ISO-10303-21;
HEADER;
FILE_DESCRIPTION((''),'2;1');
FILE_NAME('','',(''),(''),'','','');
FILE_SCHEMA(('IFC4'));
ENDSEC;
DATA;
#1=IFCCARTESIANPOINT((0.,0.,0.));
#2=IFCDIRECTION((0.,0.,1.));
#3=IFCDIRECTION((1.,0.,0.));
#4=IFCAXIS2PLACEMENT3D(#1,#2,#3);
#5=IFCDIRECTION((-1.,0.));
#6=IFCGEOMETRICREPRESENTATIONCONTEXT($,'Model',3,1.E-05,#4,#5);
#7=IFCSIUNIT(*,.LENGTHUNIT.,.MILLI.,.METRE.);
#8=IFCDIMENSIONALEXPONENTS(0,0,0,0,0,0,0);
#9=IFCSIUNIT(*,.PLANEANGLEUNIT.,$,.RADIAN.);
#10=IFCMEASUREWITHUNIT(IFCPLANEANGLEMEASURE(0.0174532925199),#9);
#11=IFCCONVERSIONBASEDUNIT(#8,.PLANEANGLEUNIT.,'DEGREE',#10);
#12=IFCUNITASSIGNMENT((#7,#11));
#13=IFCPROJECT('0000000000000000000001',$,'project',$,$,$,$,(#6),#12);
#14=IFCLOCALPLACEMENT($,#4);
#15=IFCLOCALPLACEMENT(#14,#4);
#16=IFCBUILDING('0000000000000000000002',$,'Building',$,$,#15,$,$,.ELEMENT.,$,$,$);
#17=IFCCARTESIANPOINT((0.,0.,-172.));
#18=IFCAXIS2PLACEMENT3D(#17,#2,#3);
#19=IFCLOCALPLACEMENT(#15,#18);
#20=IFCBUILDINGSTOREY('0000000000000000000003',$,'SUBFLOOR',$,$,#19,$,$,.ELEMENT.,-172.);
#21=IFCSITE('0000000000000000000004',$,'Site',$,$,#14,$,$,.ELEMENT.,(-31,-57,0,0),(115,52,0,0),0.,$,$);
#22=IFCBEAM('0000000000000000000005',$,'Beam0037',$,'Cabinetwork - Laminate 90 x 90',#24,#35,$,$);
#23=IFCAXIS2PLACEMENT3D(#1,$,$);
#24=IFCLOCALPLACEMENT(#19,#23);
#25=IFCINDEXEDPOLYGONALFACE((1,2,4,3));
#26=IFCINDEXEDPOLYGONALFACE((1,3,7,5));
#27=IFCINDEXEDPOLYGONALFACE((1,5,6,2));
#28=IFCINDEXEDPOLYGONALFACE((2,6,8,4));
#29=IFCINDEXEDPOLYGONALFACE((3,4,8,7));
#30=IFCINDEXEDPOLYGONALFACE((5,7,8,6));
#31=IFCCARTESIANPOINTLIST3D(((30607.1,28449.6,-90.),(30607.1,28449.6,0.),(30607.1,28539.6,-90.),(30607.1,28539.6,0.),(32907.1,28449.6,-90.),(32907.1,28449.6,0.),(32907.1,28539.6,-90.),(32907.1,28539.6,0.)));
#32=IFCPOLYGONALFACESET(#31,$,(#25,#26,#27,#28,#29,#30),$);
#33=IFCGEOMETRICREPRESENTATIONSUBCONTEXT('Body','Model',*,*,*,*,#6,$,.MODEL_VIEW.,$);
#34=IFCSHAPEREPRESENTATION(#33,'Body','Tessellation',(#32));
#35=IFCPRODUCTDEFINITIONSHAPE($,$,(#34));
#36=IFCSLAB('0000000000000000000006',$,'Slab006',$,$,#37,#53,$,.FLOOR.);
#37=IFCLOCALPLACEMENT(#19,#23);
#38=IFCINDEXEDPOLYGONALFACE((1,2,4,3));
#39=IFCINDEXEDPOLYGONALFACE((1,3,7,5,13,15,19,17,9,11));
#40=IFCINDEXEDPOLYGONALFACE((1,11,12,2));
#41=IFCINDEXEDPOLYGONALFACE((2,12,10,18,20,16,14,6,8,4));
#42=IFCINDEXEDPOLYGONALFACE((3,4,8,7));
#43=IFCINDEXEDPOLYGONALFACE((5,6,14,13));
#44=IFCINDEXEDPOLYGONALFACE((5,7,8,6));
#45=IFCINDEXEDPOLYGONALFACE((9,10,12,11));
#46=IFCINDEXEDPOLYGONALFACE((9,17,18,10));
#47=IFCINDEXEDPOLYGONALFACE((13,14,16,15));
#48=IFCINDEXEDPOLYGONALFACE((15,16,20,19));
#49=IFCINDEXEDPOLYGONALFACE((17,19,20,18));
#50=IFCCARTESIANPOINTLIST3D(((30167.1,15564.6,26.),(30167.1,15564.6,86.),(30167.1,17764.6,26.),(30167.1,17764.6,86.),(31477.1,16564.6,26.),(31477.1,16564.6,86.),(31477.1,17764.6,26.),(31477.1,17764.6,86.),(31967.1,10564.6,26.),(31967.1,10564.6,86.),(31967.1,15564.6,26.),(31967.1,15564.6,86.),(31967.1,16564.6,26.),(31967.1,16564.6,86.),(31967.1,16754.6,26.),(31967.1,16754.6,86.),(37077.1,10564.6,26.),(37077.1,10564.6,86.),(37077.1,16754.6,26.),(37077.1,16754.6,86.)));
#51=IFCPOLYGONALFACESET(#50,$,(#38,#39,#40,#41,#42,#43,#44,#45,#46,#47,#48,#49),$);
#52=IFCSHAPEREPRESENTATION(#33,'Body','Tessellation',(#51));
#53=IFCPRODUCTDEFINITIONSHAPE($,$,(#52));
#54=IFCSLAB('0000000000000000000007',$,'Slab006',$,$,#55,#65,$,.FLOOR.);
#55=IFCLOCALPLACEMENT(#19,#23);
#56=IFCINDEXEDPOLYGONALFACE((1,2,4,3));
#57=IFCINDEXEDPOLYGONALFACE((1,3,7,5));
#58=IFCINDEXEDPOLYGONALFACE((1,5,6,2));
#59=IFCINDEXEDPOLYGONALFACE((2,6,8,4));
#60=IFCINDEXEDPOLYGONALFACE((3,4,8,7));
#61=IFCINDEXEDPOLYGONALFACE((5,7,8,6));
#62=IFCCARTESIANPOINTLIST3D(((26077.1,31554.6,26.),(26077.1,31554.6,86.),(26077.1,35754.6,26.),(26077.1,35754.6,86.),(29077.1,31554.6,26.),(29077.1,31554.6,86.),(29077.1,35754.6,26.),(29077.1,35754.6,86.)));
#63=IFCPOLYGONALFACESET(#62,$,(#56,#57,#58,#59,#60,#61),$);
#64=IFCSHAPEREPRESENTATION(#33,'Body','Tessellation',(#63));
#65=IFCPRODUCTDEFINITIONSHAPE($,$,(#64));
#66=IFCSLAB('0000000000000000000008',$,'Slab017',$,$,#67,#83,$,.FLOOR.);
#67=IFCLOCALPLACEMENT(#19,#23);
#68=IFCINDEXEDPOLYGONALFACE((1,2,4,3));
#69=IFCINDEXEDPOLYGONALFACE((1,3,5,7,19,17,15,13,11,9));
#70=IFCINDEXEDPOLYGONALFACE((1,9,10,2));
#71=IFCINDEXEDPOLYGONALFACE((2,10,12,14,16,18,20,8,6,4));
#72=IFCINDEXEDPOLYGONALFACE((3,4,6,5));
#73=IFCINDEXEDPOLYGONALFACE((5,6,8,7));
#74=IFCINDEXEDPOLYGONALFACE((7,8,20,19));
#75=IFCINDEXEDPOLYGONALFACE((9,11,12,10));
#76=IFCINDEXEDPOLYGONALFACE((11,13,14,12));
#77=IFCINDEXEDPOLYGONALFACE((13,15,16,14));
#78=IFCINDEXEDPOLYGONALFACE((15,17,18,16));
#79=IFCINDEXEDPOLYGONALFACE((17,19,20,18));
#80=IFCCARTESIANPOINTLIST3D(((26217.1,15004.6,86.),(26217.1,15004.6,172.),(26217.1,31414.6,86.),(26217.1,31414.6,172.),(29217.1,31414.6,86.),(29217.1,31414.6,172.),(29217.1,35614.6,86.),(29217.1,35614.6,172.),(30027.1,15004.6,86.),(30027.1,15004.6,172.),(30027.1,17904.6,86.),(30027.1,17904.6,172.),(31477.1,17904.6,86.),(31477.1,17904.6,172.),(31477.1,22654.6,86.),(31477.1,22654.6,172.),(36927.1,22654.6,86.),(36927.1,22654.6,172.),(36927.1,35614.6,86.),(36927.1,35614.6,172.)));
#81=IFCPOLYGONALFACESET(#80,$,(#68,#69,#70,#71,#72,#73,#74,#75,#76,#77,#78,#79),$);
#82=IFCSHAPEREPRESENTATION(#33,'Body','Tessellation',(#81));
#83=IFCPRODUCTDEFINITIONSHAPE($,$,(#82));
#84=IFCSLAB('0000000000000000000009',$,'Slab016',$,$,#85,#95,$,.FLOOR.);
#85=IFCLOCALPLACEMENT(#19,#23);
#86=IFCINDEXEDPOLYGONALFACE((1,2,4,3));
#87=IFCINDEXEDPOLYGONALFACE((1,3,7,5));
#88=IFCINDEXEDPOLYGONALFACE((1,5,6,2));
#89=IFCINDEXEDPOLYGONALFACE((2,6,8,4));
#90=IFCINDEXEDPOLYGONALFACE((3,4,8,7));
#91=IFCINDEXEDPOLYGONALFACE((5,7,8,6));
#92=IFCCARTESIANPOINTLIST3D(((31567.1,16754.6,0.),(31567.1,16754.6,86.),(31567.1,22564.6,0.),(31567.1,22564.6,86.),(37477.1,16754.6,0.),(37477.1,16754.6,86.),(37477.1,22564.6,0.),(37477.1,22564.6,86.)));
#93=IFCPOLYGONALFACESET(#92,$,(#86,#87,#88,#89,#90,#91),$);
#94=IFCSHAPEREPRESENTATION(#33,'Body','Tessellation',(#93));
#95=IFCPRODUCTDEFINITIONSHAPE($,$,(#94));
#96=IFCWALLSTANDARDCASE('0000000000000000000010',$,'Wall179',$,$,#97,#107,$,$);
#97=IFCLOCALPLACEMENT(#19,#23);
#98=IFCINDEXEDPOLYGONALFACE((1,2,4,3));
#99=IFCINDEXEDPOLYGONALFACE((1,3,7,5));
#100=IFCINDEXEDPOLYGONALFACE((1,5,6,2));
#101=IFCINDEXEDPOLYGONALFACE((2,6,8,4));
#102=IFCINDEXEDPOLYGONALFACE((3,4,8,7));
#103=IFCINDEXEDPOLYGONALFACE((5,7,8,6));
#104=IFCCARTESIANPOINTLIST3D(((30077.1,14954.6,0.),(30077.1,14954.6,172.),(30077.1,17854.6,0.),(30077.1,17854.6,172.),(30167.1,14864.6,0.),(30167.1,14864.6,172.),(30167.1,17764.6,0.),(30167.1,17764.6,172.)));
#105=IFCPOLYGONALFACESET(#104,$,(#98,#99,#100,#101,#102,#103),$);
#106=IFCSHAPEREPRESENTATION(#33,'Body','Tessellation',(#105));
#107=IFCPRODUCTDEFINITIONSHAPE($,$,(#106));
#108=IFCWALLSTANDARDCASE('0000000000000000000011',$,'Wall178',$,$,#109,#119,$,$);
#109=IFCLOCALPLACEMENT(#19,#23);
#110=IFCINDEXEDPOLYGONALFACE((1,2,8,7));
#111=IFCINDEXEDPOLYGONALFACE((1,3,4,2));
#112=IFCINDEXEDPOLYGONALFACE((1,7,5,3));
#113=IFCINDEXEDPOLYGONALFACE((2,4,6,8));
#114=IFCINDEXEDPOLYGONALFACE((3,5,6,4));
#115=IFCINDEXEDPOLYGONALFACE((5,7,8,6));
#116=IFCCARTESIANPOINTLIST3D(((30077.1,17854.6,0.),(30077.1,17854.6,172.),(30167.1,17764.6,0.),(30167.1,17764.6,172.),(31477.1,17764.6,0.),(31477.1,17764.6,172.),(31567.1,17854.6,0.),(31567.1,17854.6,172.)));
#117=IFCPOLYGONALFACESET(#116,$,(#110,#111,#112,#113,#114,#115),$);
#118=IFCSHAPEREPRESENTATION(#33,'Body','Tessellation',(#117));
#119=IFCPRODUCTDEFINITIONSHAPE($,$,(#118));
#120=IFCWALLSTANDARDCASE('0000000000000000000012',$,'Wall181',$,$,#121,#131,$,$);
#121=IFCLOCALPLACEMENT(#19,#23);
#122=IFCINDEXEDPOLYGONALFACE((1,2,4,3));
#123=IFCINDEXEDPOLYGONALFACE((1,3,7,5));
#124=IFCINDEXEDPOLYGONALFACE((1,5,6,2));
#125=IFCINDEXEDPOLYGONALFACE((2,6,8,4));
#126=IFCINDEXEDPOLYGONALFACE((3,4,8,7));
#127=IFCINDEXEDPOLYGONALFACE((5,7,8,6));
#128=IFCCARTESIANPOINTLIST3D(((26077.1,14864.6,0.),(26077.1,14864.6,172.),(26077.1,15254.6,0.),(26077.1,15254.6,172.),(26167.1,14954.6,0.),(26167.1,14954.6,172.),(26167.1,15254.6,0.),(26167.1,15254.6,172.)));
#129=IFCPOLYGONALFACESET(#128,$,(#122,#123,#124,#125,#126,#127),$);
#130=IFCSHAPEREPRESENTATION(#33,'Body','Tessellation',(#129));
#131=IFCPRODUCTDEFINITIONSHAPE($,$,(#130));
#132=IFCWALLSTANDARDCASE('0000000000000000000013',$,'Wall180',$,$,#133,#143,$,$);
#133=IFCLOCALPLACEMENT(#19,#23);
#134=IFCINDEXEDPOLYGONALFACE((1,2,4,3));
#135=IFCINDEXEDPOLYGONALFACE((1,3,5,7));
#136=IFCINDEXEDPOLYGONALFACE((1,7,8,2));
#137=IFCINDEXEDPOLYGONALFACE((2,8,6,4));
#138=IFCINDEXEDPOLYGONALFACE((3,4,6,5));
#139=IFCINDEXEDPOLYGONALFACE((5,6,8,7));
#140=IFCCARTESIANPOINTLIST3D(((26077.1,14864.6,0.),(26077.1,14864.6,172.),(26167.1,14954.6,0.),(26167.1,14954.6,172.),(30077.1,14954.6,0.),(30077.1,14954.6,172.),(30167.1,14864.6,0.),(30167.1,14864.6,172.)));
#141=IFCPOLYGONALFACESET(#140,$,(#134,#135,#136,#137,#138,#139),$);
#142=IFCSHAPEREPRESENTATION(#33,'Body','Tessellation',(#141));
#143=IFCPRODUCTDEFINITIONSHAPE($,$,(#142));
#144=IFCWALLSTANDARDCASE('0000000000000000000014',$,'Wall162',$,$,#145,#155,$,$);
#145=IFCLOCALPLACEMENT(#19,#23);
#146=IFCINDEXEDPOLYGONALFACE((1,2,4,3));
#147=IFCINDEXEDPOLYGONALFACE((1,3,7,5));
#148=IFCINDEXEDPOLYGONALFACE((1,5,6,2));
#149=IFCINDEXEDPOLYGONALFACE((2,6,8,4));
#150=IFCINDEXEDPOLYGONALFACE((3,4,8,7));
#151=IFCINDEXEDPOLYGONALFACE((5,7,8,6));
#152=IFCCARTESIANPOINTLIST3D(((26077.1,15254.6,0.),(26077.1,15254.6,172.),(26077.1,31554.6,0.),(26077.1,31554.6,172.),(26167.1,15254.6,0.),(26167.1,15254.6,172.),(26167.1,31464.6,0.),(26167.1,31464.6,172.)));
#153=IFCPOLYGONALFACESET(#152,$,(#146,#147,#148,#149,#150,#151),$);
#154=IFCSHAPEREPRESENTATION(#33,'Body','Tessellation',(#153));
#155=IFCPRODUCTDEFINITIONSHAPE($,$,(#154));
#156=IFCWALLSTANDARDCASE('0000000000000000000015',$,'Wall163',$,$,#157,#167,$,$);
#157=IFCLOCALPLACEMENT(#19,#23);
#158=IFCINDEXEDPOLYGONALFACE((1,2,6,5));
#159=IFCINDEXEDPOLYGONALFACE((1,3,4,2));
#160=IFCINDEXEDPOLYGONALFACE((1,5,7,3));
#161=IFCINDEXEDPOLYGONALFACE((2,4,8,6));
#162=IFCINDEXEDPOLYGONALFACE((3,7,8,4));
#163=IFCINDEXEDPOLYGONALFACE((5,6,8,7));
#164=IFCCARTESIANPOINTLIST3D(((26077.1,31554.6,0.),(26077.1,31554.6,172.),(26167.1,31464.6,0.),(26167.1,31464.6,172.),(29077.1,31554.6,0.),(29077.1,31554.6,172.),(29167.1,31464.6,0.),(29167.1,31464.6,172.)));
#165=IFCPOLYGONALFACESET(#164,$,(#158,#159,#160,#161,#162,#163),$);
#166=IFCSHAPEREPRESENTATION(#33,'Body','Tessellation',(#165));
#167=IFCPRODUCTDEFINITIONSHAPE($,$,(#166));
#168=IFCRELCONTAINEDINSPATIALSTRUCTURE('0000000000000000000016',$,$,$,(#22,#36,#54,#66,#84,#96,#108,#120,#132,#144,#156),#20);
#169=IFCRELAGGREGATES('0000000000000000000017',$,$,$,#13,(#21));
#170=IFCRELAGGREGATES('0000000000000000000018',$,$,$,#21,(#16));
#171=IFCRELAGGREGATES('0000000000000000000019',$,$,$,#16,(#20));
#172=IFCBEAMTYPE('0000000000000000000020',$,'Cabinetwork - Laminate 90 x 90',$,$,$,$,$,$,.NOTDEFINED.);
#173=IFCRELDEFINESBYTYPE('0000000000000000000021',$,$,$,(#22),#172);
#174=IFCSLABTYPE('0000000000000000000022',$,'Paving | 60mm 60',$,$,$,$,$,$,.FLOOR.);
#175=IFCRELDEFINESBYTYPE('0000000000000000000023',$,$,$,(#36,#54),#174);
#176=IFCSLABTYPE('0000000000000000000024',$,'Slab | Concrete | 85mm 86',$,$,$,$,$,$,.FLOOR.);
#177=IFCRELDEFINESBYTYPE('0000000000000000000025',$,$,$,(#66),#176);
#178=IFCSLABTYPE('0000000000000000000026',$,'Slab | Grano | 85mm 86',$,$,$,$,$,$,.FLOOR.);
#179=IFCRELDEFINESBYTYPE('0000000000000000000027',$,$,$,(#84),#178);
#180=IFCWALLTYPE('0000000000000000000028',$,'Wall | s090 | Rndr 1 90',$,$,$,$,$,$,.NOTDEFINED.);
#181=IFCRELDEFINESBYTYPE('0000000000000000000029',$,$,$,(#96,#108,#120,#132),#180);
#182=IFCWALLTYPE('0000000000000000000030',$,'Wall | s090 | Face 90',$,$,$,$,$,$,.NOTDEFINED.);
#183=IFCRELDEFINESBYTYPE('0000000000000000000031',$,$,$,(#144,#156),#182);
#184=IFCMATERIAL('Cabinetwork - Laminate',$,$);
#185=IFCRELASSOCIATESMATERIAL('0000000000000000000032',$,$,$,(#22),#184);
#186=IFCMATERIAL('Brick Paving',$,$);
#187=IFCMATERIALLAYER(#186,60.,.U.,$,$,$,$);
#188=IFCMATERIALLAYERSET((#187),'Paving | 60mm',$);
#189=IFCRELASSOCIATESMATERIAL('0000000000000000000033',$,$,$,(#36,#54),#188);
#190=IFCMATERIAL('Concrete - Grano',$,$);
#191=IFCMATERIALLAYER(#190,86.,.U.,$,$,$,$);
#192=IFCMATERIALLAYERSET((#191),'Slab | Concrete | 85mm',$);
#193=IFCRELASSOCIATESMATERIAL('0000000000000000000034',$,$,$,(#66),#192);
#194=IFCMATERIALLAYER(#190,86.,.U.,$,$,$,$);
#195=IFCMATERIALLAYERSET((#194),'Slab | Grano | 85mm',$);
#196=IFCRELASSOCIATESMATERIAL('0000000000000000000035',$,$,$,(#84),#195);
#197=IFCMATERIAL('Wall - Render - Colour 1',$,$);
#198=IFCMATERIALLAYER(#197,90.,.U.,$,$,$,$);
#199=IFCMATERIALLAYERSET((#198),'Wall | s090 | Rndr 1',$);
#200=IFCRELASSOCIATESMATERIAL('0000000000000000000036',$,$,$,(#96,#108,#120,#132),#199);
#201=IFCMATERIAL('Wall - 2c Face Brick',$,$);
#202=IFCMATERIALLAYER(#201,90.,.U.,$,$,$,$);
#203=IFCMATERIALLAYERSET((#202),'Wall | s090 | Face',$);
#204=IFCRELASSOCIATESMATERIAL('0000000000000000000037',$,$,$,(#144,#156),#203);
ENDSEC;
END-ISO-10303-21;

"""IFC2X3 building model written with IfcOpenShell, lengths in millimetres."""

from ifc_helpers import new_model, entity, si_unit, converted_unit, direction, frame, frame_2d, origin_with_axes, place, context, subcontext, project, spatial, polyline, rectangle, outline, extrude, material, layer, layer_set, layer_usage, type_object, element, save


model = new_model("IFC2X3")

# Units and contexts
model_context = context("Model", 3, precision=1e-05, world=origin_with_axes(), true_north=direction((-1.0, 0.0)))
body_context = subcontext(model_context, "Body", "Model", "MODEL_VIEW")
ifc_project = project(units=[si_unit("LENGTHUNIT", "METRE", prefix="MILLI"), converted_unit("PLANEANGLEUNIT", "DEGREE", entity("IfcPlaneAngleMeasure", 0.0174532925199), si_unit("PLANEANGLEUNIT", "RADIAN"), dimensions=[0, 0, 0, 0, 0, 0, 0])], contexts=[model_context])

# Site, building, storey
site_placement = place(None, origin_with_axes())
site = spatial("IfcSite", under=ifc_project, at=site_placement, Name="Site", CompositionType="ELEMENT", RefLatitude=(-31, -57, 0, 0), RefLongitude=(115, 52, 0, 0), RefElevation=0.0)
building_placement = place(site_placement, origin_with_axes())
building = spatial("IfcBuilding", under=site, at=building_placement, Name="Building", CompositionType="ELEMENT")
storey_placement = place(building_placement, frame((0.0, 0.0, -172.0), z_axis=(0.0, 0.0, 1.0), x_axis=(1.0, 0.0, 0.0)))
storey = spatial("IfcBuildingStorey", under=building, at=storey_placement, Name="SUBFLOOR", CompositionType="ELEMENT", Elevation=-172.0)

# Beam
ifc_material_1 = material(Name="Cabinetwork - Laminate")
beam_type = type_object("IfcBeamType", Name="Cabinetwork - Laminate 90 x 90", PredefinedType="NOTDEFINED")
beam_placement = place(storey_placement, frame((30607.1, 28494.6, 0.0), z_axis=(0.0, 0.0, 1.0), x_axis=(0.0, -1.0, 0.0)))
element("IfcBeam", 1, at=beam_placement, inside=storey, type_object=beam_type, material=ifc_material_1, Name="Beam0037", ObjectType="Cabinetwork - Laminate 90 x 90", context=body_context, shape_type="SweptSolid", body=[
    extrude(rectangle(XDim=90.0, YDim=90.0, at=frame_2d((-45.0, 0.0), x_axis=(1.0, 0.0))), frame((0.0, 0.0, 0.0), z_axis=(0.0, 1.0, 0.0), x_axis=(0.0, 0.0, 1.0)), (0.0, 0.0, 1.0), 2300.0),
])

# Slabs
ifc_material_2 = material(Name="Brick Paving")
ifc_layer_1 = layer(ifc_material_2, 60.0, ventilated="UNKNOWN")
ifc_layer_set_1 = layer_set([ifc_layer_1], Name="Paving | 60mm")
ifc_layer_usage_1 = layer_usage(ifc_layer_set_1, "AXIS3", "NEGATIVE", 60.0)
slab_type_1 = type_object("IfcSlabType", Name="Paving | 60mm 60", PredefinedType="FLOOR")
slab_1_placement = place(storey_placement, frame((31477.1, 17764.6, 86.0), z_axis=(0.0, 0.0, 1.0), x_axis=(1.0, 0.0, 0.0)))
element("IfcSlab", 2, at=slab_1_placement, inside=storey, type_object=slab_type_1, material=ifc_layer_usage_1, Name="Slab006", PredefinedType="FLOOR", context=body_context, shape_type="SweptSolid", body=[
    extrude(outline(polyline([(0.0, 0.0), (-1310.0, 0.0), (-1310.0, -2200.0), (490.0, -2200.0), (490.0, -7200.0), (5600.0, -7200.0), (5600.0, -1010.0), (490.0, -1010.0), (490.0, -1200.0), (0.0, -1200.0), (0.0, 0.0)])), frame((0.0, 0.0, -60.0), z_axis=(0.0, 0.0, 1.0), x_axis=(1.0, 0.0, 0.0)), (0.0, 0.0, 1.0), 60.0),
])
ifc_layer_usage_2 = layer_usage(ifc_layer_set_1, "AXIS3", "NEGATIVE", 60.0)
slab_2_placement = place(storey_placement, frame((26077.1, 31554.6, 86.0), z_axis=(0.0, 0.0, 1.0), x_axis=(1.0, 0.0, 0.0)))
element("IfcSlab", 3, at=slab_2_placement, inside=storey, type_object=slab_type_1, material=ifc_layer_usage_2, Name="Slab006", PredefinedType="FLOOR", context=body_context, shape_type="SweptSolid", body=[
    extrude(outline(polyline([(0.0, 0.0), (3000.0, 0.0), (3000.0, 4200.0), (0.0, 4200.0), (0.0, 0.0)])), frame((0.0, 0.0, -60.0), z_axis=(0.0, 0.0, 1.0), x_axis=(1.0, 0.0, 0.0)), (0.0, 0.0, 1.0), 60.0),
])
ifc_material_3 = material(Name="Concrete - Grano")
ifc_layer_2 = layer(ifc_material_3, 86.0, ventilated="UNKNOWN")
ifc_layer_set_2 = layer_set([ifc_layer_2], Name="Slab | Concrete | 85mm")
ifc_layer_usage_3 = layer_usage(ifc_layer_set_2, "AXIS3", "NEGATIVE", 86.0)
slab_type_2 = type_object("IfcSlabType", Name="Slab | Concrete | 85mm 86", PredefinedType="FLOOR")
slab_3_placement = place(storey_placement, frame((29217.1, 31414.6, 172.0), z_axis=(0.0, 0.0, 1.0), x_axis=(1.0, 0.0, 0.0)))
element("IfcSlab", 4, at=slab_3_placement, inside=storey, type_object=slab_type_2, material=ifc_layer_usage_3, Name="Slab017", PredefinedType="FLOOR", context=body_context, shape_type="SweptSolid", body=[
    extrude(outline(polyline([(0.0, 0.0), (-3000.0, 0.0), (-3000.0, -16410.0), (810.0, -16410.0), (810.0, -13510.0), (2260.0, -13510.0), (2260.0, -8760.0), (7710.0, -8760.0), (7710.0, 4200.0), (0.0, 4200.0), (0.0, 0.0)])), frame((0.0, 0.0, -86.0), z_axis=(0.0, 0.0, 1.0), x_axis=(1.0, 0.0, 0.0)), (0.0, 0.0, 1.0), 86.0),
])
ifc_layer_3 = layer(ifc_material_3, 86.0, ventilated="UNKNOWN")
ifc_layer_set_3 = layer_set([ifc_layer_3], Name="Slab | Grano | 85mm")
ifc_layer_usage_4 = layer_usage(ifc_layer_set_3, "AXIS3", "NEGATIVE", 86.0)
slab_type_3 = type_object("IfcSlabType", Name="Slab | Grano | 85mm 86", PredefinedType="FLOOR")
slab_4_placement = place(storey_placement, frame((37477.1, 22564.6, 86.0), z_axis=(0.0, 0.0, 1.0), x_axis=(1.0, 0.0, 0.0)))
element("IfcSlab", 5, at=slab_4_placement, inside=storey, type_object=slab_type_3, material=ifc_layer_usage_4, Name="Slab016", PredefinedType="FLOOR", context=body_context, shape_type="SweptSolid", body=[
    extrude(outline(polyline([(0.0, 0.0), (-5910.0, 0.0), (-5910.0, -5810.0), (0.0, -5810.0), (0.0, 0.0)])), frame((0.0, 0.0, -86.0), z_axis=(0.0, 0.0, 1.0), x_axis=(1.0, 0.0, 0.0)), (0.0, 0.0, 1.0), 86.0),
])

# Walls
ifc_material_4 = material(Name="Wall - Render - Colour 1")
ifc_layer_4 = layer(ifc_material_4, 90.0, ventilated="UNKNOWN")
ifc_layer_set_4 = layer_set([ifc_layer_4], Name="Wall | s090 | Rndr 1")
ifc_layer_usage_5 = layer_usage(ifc_layer_set_4, "AXIS2", "NEGATIVE", 0.0)
wall_type_1 = type_object("IfcWallType", Name="Wall | s090 | Rndr 1 90", PredefinedType="NOTDEFINED")
wall_1_placement = place(storey_placement, frame((30167.1, 17764.6, 0.0), z_axis=(0.0, 0.0, 1.0), x_axis=(0.0, -1.0, 0.0)))
element("IfcWallStandardCase", 6, at=wall_1_placement, inside=storey, type_object=wall_type_1, material=ifc_layer_usage_5, Name="Wall179", context=body_context, shape_type="SweptSolid", body=[
    extrude(outline(polyline([(-90.0, -90.0), (2810.0, -90.0), (2900.0, 0.0), (0.0, 0.0), (-90.0, -90.0)])), origin_with_axes(), (0.0, 0.0, 1.0), 172.0),
])
ifc_layer_usage_6 = layer_usage(ifc_layer_set_4, "AXIS2", "NEGATIVE", 0.0)
wall_2_placement = place(storey_placement, frame((31477.1, 17764.6, 0.0), z_axis=(0.0, 0.0, 1.0), x_axis=(-1.0, 0.0, 0.0)))
element("IfcWallStandardCase", 7, at=wall_2_placement, inside=storey, type_object=wall_type_1, material=ifc_layer_usage_6, Name="Wall178", context=body_context, shape_type="SweptSolid", body=[
    extrude(outline(polyline([(-90.0, -90.0), (1400.0, -90.0), (1310.0, 0.0), (0.0, 0.0), (-90.0, -90.0)])), origin_with_axes(), (0.0, 0.0, 1.0), 172.0),
])
ifc_layer_usage_7 = layer_usage(ifc_layer_set_4, "AXIS2", "NEGATIVE", 0.0)
wall_3_placement = place(storey_placement, frame((26077.1, 14864.6, 0.0), z_axis=(0.0, 0.0, 1.0), x_axis=(0.0, 1.0, 0.0)))
element("IfcWallStandardCase", 8, at=wall_3_placement, inside=storey, type_object=wall_type_1, material=ifc_layer_usage_7, Name="Wall181", context=body_context, shape_type="SweptSolid", body=[
    extrude(outline(polyline([(90.0, -90.0), (390.0, -90.0), (390.0, 0.0), (0.0, 0.0), (90.0, -90.0)])), origin_with_axes(), (0.0, 0.0, 1.0), 172.0),
])
ifc_layer_usage_8 = layer_usage(ifc_layer_set_4, "AXIS2", "NEGATIVE", 0.0)
wall_4_placement = place(storey_placement, frame((30167.1, 14864.6, 0.0), z_axis=(0.0, 0.0, 1.0), x_axis=(-1.0, 0.0, 0.0)))
element("IfcWallStandardCase", 9, at=wall_4_placement, inside=storey, type_object=wall_type_1, material=ifc_layer_usage_8, Name="Wall180", context=body_context, shape_type="SweptSolid", body=[
    extrude(outline(polyline([(90.0, -90.0), (4000.0, -90.0), (4090.0, 0.0), (0.0, 0.0), (90.0, -90.0)])), origin_with_axes(), (0.0, 0.0, 1.0), 172.0),
])
ifc_material_5 = material(Name="Wall - 2c Face Brick")
ifc_layer_5 = layer(ifc_material_5, 90.0, ventilated="UNKNOWN")
ifc_layer_set_5 = layer_set([ifc_layer_5], Name="Wall | s090 | Face")
ifc_layer_usage_9 = layer_usage(ifc_layer_set_5, "AXIS2", "NEGATIVE", 0.0)
wall_type_2 = type_object("IfcWallType", Name="Wall | s090 | Face 90", PredefinedType="NOTDEFINED")
wall_5_placement = place(storey_placement, frame((26077.1, 15254.6, 0.0), z_axis=(0.0, 0.0, 1.0), x_axis=(0.0, 1.0, 0.0)))
element("IfcWallStandardCase", 10, at=wall_5_placement, inside=storey, type_object=wall_type_2, material=ifc_layer_usage_9, Name="Wall162", context=body_context, shape_type="SweptSolid", body=[
    extrude(outline(polyline([(0.0, -90.0), (16210.0, -90.0), (16300.0, 0.0), (0.0, 0.0), (0.0, -90.0)])), origin_with_axes(), (0.0, 0.0, 1.0), 172.0),
])
ifc_layer_usage_10 = layer_usage(ifc_layer_set_5, "AXIS2", "NEGATIVE", 0.0)
wall_6_placement = place(storey_placement, frame((26077.1, 31554.6, 0.0), z_axis=(0.0, 0.0, 1.0), x_axis=(1.0, 0.0, 0.0)))
element("IfcWallStandardCase", 11, at=wall_6_placement, inside=storey, type_object=wall_type_2, material=ifc_layer_usage_10, Name="Wall163", context=body_context, shape_type="SweptSolid", body=[
    extrude(outline(polyline([(90.0, -90.0), (3090.0, -90.0), (3000.0, 0.0), (0.0, 0.0), (90.0, -90.0)])), origin_with_axes(), (0.0, 0.0, 1.0), 172.0),
])

save(model, "model.ifc")
